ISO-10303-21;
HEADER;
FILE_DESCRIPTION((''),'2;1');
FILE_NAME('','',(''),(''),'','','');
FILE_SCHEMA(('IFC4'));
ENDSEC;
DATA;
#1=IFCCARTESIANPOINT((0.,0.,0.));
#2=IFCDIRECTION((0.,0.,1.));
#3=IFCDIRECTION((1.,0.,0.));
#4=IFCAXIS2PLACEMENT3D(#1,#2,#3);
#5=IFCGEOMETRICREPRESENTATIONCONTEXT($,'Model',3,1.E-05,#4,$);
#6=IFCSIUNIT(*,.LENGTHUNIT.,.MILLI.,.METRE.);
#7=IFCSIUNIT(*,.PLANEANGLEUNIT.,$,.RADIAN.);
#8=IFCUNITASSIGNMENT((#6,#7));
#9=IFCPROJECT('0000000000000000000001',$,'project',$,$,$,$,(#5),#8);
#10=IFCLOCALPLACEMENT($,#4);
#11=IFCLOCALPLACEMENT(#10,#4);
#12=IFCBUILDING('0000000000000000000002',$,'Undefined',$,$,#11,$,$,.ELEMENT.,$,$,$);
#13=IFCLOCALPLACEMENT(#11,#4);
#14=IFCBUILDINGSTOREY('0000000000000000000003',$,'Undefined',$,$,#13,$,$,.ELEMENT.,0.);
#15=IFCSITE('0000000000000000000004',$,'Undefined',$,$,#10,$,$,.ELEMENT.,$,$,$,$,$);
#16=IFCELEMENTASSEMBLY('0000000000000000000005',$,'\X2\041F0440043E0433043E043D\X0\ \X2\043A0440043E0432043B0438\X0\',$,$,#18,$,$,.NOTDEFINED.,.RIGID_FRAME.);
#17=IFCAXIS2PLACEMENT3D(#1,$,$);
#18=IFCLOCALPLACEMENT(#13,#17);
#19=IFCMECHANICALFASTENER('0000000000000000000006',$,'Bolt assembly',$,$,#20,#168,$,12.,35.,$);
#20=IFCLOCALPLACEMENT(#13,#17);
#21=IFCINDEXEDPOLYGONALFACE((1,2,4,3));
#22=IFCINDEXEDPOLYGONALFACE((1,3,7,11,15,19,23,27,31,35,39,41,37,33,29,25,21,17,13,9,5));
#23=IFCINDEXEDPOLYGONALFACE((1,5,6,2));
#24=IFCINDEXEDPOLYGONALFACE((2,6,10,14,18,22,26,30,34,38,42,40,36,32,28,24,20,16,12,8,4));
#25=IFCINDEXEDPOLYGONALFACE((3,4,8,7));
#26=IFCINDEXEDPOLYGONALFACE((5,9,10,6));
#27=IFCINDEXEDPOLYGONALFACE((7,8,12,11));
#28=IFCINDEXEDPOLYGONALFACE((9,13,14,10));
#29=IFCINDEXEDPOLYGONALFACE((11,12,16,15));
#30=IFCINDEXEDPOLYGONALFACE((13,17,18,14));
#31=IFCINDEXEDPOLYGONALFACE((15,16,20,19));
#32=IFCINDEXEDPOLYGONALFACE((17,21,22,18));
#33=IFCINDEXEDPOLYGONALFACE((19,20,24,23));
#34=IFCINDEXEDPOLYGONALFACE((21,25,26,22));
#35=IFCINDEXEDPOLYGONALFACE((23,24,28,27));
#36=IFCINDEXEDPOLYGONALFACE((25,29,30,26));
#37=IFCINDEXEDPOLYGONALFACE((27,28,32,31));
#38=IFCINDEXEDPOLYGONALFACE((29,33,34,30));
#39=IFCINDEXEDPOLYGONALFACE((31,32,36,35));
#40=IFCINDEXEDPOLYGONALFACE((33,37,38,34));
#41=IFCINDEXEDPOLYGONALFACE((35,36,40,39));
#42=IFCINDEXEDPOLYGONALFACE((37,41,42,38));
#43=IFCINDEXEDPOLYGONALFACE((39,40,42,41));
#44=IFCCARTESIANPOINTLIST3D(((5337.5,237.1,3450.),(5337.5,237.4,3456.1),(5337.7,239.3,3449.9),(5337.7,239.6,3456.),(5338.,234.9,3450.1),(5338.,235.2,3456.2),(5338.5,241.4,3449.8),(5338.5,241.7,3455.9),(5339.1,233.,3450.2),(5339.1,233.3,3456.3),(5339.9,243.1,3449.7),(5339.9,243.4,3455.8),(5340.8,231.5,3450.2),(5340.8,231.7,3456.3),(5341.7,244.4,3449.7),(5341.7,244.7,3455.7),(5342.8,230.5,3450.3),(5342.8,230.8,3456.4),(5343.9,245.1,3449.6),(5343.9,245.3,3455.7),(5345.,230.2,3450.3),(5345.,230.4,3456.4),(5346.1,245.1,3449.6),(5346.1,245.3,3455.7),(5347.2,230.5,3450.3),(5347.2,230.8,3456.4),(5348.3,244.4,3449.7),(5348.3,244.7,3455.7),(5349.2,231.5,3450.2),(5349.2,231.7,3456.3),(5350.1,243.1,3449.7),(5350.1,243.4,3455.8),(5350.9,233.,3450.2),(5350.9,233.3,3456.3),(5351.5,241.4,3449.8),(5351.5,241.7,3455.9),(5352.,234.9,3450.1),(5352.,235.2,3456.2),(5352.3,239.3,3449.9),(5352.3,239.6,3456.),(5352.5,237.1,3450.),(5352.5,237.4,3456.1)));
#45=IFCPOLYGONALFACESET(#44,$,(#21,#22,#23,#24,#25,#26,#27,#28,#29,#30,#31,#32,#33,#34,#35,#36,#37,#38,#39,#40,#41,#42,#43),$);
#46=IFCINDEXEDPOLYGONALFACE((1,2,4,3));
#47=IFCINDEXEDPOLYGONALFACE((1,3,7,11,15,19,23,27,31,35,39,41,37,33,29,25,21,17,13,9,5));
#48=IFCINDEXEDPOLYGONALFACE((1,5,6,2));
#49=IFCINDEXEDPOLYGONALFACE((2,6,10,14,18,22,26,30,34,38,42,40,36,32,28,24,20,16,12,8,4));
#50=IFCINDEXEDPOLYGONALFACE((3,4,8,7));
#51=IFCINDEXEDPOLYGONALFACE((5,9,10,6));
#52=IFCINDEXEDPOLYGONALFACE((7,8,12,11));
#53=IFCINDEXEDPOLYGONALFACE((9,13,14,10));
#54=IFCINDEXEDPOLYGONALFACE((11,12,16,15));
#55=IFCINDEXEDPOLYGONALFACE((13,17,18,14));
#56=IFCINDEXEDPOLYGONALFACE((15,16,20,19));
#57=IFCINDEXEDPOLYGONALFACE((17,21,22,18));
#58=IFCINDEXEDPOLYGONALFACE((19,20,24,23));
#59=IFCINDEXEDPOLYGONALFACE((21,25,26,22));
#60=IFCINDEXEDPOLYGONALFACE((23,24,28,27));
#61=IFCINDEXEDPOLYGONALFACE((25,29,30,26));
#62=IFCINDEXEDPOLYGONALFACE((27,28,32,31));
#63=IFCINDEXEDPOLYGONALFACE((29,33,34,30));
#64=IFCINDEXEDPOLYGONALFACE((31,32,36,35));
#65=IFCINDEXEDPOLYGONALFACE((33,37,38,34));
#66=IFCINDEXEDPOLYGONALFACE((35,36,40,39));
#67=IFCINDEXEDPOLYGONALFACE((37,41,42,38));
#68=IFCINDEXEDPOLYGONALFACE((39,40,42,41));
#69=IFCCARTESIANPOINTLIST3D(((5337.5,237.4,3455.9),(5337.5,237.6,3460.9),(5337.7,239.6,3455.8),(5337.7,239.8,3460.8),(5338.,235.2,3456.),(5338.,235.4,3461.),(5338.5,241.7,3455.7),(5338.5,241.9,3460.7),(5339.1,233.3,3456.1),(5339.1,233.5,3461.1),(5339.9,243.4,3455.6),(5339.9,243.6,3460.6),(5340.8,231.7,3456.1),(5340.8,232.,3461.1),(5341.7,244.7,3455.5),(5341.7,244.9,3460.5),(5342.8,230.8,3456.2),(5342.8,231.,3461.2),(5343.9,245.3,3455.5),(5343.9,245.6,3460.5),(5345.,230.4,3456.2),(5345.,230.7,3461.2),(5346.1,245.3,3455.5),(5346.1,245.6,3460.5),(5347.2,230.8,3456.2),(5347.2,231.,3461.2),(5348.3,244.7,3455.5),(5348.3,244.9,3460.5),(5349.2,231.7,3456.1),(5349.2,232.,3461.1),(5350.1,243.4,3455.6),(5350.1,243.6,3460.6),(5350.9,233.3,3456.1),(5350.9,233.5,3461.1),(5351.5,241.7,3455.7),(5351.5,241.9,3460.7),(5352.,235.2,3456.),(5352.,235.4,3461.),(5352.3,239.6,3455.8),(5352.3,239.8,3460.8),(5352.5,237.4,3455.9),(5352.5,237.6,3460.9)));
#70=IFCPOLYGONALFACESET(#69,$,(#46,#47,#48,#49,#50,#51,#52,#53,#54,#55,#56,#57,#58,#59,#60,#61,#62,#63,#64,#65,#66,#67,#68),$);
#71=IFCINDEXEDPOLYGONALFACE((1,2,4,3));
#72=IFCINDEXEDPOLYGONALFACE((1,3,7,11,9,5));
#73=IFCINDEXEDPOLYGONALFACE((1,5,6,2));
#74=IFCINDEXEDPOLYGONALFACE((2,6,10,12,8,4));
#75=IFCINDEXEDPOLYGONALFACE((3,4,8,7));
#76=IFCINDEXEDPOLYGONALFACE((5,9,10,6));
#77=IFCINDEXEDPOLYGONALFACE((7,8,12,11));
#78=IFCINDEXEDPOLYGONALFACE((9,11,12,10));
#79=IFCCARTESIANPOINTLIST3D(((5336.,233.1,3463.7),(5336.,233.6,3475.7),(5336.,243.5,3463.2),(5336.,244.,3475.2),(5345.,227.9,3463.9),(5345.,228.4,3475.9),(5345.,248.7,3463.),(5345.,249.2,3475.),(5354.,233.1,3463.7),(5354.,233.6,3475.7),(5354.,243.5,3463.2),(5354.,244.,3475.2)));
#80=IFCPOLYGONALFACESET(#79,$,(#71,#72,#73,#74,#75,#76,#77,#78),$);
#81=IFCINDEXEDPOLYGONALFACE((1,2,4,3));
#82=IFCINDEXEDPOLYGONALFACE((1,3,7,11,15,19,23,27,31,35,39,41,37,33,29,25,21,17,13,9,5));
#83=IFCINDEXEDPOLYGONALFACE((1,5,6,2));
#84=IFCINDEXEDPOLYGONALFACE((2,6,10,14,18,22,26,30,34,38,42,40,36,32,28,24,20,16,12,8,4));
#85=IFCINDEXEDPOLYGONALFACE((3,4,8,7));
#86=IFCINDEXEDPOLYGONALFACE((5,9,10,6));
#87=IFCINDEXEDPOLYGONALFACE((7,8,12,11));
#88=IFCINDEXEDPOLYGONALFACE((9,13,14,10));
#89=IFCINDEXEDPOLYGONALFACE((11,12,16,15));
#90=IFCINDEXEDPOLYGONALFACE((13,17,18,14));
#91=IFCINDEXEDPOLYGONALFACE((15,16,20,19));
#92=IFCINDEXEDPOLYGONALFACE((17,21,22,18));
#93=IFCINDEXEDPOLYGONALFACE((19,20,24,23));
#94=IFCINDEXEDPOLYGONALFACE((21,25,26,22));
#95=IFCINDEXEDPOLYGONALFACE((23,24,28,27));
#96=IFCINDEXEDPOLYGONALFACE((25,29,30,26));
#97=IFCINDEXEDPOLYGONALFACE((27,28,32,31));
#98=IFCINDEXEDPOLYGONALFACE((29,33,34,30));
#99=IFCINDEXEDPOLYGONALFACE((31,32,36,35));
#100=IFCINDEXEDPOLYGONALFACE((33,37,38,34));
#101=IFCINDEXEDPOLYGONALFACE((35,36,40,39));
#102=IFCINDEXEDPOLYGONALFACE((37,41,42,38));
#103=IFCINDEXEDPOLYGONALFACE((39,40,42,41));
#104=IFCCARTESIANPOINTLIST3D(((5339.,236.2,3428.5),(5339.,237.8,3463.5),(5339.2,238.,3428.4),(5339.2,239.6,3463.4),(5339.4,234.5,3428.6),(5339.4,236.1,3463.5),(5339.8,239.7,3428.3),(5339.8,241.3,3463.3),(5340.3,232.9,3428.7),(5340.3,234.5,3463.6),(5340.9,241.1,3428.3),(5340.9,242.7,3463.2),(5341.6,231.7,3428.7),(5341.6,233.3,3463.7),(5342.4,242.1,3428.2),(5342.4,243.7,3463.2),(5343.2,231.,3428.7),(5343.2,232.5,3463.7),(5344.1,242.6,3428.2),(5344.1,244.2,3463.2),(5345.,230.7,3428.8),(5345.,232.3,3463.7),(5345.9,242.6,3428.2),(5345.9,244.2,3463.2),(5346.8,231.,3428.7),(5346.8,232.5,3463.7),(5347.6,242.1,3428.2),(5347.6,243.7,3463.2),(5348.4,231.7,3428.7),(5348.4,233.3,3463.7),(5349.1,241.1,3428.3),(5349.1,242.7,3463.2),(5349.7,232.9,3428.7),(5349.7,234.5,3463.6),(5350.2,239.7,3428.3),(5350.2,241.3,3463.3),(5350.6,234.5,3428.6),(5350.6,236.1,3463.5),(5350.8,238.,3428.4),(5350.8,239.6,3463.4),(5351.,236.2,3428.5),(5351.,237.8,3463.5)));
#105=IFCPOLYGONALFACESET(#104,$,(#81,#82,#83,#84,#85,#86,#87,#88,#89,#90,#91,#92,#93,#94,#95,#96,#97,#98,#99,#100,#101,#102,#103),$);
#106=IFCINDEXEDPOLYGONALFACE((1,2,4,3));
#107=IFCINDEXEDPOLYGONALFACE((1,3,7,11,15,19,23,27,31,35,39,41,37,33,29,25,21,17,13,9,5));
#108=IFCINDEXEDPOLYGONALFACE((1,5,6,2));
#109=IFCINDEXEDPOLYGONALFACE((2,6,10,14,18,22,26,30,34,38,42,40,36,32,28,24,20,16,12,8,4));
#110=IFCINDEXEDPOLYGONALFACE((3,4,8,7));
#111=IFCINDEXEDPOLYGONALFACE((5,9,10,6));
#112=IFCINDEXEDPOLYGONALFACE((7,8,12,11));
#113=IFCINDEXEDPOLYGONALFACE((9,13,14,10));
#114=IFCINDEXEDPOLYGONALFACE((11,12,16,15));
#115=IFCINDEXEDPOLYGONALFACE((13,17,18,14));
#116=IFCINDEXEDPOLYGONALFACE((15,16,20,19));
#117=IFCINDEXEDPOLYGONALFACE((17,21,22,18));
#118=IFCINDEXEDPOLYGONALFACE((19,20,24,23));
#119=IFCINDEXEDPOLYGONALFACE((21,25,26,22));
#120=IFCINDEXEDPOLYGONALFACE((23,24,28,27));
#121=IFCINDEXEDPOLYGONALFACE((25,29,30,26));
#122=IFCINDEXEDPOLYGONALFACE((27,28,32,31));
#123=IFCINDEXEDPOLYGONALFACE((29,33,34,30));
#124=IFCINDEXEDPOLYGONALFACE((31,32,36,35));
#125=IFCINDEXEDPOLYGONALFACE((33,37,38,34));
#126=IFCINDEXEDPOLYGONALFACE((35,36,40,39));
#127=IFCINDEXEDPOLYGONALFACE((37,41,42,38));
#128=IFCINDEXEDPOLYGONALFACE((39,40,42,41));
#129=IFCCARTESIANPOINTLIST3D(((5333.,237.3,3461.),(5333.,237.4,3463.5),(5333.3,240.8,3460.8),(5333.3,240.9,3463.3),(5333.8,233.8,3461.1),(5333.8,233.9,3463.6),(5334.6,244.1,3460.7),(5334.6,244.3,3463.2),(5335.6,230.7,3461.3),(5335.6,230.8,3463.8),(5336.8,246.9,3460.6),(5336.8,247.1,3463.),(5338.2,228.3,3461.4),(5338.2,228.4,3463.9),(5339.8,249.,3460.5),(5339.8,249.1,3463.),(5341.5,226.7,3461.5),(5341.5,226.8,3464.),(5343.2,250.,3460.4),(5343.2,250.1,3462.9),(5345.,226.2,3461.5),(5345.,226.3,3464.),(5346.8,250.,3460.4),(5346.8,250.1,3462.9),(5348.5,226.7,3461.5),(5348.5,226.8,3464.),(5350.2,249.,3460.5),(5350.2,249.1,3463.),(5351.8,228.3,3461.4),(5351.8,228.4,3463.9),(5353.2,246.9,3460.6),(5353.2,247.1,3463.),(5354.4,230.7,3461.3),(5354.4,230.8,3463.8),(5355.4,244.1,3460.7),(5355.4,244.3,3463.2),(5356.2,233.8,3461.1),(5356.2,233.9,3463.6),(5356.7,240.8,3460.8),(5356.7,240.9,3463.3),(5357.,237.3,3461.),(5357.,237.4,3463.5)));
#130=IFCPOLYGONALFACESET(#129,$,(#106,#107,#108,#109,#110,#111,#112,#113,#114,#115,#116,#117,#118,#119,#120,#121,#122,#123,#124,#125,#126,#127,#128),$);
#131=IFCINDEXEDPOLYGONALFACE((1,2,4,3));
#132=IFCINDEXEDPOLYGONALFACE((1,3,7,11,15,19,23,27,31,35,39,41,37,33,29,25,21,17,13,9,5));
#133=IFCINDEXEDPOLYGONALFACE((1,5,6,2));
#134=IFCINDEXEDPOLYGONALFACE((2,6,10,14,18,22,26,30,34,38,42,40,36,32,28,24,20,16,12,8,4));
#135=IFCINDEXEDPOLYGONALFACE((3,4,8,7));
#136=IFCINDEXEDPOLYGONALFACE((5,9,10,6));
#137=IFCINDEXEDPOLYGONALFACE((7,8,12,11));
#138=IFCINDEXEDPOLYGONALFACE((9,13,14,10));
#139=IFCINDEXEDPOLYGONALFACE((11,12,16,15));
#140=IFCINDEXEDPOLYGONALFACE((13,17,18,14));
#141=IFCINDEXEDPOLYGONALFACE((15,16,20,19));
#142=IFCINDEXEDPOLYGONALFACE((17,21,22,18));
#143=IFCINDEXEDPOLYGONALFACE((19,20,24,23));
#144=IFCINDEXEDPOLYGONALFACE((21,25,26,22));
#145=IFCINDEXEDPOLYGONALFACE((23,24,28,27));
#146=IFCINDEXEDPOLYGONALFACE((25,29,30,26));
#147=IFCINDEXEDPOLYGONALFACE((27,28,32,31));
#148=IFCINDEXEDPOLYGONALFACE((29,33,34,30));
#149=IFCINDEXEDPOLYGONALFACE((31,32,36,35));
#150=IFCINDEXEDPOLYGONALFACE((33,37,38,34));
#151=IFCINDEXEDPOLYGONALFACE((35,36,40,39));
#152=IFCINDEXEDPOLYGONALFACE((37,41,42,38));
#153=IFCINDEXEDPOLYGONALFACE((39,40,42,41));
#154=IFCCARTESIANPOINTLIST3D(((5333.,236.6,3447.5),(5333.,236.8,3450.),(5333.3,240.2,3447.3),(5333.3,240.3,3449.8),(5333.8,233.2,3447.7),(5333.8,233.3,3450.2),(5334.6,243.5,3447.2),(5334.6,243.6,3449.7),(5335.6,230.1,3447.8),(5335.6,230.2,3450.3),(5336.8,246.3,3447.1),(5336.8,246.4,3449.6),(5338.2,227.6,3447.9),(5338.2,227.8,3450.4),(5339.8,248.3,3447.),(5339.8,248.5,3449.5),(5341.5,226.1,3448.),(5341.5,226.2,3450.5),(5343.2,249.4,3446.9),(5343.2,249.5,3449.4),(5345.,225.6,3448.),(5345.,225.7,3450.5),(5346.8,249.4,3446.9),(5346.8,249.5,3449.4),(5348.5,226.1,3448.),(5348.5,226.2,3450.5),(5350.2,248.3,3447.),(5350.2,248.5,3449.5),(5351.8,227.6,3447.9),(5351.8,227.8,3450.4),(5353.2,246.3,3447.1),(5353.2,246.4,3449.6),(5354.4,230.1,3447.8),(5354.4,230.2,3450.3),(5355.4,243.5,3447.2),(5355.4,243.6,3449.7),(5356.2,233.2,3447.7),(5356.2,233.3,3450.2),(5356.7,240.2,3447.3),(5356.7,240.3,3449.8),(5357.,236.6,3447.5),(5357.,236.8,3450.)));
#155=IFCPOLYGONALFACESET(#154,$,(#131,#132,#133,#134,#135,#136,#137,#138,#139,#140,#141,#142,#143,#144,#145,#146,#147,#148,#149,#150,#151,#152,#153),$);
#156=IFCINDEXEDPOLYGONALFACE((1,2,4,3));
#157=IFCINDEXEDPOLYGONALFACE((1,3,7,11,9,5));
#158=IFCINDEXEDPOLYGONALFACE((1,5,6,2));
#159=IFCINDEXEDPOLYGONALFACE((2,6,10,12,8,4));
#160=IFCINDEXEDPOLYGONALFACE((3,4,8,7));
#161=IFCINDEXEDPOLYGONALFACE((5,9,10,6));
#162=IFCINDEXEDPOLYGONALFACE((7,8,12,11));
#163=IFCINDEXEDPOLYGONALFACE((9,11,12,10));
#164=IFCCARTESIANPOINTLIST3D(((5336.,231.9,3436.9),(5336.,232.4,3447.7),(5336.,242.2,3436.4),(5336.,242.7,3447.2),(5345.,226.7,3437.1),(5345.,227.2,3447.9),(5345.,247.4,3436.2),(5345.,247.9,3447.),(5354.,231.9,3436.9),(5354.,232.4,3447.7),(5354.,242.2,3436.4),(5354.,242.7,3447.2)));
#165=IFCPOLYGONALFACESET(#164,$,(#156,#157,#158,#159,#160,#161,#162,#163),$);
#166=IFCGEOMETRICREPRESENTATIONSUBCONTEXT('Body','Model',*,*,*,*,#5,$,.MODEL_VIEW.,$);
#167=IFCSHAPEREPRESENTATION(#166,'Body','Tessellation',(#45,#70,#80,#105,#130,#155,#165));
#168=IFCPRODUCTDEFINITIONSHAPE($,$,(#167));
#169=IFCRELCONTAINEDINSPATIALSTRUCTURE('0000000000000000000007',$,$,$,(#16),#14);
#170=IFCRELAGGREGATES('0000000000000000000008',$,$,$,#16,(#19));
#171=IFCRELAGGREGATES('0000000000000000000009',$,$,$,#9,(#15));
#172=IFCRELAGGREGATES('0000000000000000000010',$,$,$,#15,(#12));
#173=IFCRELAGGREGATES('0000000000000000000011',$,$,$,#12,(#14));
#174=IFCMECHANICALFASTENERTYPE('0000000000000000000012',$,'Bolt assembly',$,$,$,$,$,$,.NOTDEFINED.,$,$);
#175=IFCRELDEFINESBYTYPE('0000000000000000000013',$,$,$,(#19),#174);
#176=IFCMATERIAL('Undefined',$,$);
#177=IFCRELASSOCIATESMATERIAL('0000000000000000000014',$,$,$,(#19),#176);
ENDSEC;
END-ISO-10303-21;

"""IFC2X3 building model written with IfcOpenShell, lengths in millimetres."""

from ifc_helpers import new_model, si_unit, frame, origin_with_axes, origin_2d_with_axis, place, context, subcontext, project, spatial, polyline, circle, outline, extrude, source, transform, mapped, material, type_object, element, aggregate, save


model = new_model("IFC2X3")

# Units and contexts
model_context = context("Model", 3, precision=1e-05, world=origin_with_axes())
body_context = subcontext(model_context, "Body", "Model", "MODEL_VIEW")
ifc_project = project(units=[si_unit("LENGTHUNIT", "METRE", prefix="MILLI"), si_unit("PLANEANGLEUNIT", "RADIAN")], contexts=[model_context])

# Site, building, storey
site_placement = place(None, origin_with_axes())
site = spatial("IfcSite", under=ifc_project, at=site_placement, Name="Undefined", CompositionType="ELEMENT")
building_placement = place(site_placement, origin_with_axes())
building = spatial("IfcBuilding", under=site, at=building_placement, Name="Undefined", CompositionType="ELEMENT")
storey_placement = place(building_placement, origin_with_axes())
storey = spatial("IfcBuildingStorey", under=building, at=storey_placement, Name="Undefined", CompositionType="ELEMENT", Elevation=0.0)

# Element assembly
assembly_1_placement = place(storey_placement, origin_with_axes())
assembly_1 = element("IfcElementAssembly", 1, at=assembly_1_placement, inside=storey, Name="Прогон кровли", AssemblyPlace="NOTDEFINED", PredefinedType="RIGID_FRAME")

# Mechanical fastener
ifc_material_1 = material(Name="Undefined")
mechanical_fastener_type = type_object("IfcMechanicalFastenerType", Name="Bolt assembly")
shared_shape_1 = source(origin_with_axes(), body_context, "Body", "SweptSolid", [
    extrude(circle(Radius=7.5, at=origin_2d_with_axis()), frame((0.0, -0.1, 0.0), z_axis=(0.0, 1.0, 0.0), x_axis=(1.0, 0.0, 0.0)), (0.0, 0.0, 1.0), 6.1),
    extrude(circle(Radius=7.5, at=origin_2d_with_axis()), frame((0.0, -4.9, 0.0), z_axis=(0.0, 1.0, 0.0), x_axis=(1.0, 0.0, 0.0)), (0.0, 0.0, 1.0), 5.0),
    extrude(outline(polyline([(10.4, 0.0), (5.2, 9.0), (-5.2, 9.0), (-10.4, 0.0), (-5.2, -9.0), (5.2, -9.0), (10.4, 0.0)])), frame((0.0, -19.5, 0.0), z_axis=(0.0, 1.0, 0.0), x_axis=(1.0, 0.0, 0.0)), (0.0, 0.0, 1.0), 12.0),
    extrude(circle(Radius=6.0, at=origin_2d_with_axis()), frame((0.0, -7.5, 0.0), z_axis=(0.0, 1.0, 0.0), x_axis=(1.0, 0.0, 0.0)), (0.0, 0.0, 1.0), 35.0),
    extrude(circle(Radius=12.0, at=origin_2d_with_axis()), frame((0.0, -7.5, 0.0), z_axis=(0.0, 1.0, 0.0), x_axis=(1.0, 0.0, 0.0)), (0.0, 0.0, 1.0), 2.5),
    extrude(circle(Radius=12.0, at=origin_2d_with_axis()), frame((0.0, 6.0, 0.0), z_axis=(0.0, 1.0, 0.0), x_axis=(1.0, 0.0, 0.0)), (0.0, 0.0, 1.0), 2.5),
    extrude(outline(polyline([(10.4, 0.0), (5.2, 9.0), (-5.2, 9.0), (-10.4, 0.0), (-5.2, -9.0), (5.2, -9.0), (10.4, 0.0)])), frame((0.0, 8.5, 0.0), z_axis=(0.0, 1.0, 0.0), x_axis=(1.0, 0.0, 0.0)), (0.0, 0.0, 1.0), 10.8),
])
mechanical_fastener_1_placement = place(assembly_1_placement, frame((5345.0, 237.9, 3456.0), z_axis=(1.0, 0.0, 0.0), x_axis=(0.0, -0.998969, 0.045408)))
mechanical_fastener_1 = element("IfcMechanicalFastener", 2, at=mechanical_fastener_1_placement, type_object=mechanical_fastener_type, material=ifc_material_1, Name="Bolt assembly", NominalDiameter=12.0, NominalLength=35.0, context=body_context, shape_type="MappedRepresentation", body=[
    mapped(shared_shape_1, transform((0.0, 0.0, 0.0))),
])
aggregate(assembly_1, [mechanical_fastener_1])

save(model, "model.ifc")
